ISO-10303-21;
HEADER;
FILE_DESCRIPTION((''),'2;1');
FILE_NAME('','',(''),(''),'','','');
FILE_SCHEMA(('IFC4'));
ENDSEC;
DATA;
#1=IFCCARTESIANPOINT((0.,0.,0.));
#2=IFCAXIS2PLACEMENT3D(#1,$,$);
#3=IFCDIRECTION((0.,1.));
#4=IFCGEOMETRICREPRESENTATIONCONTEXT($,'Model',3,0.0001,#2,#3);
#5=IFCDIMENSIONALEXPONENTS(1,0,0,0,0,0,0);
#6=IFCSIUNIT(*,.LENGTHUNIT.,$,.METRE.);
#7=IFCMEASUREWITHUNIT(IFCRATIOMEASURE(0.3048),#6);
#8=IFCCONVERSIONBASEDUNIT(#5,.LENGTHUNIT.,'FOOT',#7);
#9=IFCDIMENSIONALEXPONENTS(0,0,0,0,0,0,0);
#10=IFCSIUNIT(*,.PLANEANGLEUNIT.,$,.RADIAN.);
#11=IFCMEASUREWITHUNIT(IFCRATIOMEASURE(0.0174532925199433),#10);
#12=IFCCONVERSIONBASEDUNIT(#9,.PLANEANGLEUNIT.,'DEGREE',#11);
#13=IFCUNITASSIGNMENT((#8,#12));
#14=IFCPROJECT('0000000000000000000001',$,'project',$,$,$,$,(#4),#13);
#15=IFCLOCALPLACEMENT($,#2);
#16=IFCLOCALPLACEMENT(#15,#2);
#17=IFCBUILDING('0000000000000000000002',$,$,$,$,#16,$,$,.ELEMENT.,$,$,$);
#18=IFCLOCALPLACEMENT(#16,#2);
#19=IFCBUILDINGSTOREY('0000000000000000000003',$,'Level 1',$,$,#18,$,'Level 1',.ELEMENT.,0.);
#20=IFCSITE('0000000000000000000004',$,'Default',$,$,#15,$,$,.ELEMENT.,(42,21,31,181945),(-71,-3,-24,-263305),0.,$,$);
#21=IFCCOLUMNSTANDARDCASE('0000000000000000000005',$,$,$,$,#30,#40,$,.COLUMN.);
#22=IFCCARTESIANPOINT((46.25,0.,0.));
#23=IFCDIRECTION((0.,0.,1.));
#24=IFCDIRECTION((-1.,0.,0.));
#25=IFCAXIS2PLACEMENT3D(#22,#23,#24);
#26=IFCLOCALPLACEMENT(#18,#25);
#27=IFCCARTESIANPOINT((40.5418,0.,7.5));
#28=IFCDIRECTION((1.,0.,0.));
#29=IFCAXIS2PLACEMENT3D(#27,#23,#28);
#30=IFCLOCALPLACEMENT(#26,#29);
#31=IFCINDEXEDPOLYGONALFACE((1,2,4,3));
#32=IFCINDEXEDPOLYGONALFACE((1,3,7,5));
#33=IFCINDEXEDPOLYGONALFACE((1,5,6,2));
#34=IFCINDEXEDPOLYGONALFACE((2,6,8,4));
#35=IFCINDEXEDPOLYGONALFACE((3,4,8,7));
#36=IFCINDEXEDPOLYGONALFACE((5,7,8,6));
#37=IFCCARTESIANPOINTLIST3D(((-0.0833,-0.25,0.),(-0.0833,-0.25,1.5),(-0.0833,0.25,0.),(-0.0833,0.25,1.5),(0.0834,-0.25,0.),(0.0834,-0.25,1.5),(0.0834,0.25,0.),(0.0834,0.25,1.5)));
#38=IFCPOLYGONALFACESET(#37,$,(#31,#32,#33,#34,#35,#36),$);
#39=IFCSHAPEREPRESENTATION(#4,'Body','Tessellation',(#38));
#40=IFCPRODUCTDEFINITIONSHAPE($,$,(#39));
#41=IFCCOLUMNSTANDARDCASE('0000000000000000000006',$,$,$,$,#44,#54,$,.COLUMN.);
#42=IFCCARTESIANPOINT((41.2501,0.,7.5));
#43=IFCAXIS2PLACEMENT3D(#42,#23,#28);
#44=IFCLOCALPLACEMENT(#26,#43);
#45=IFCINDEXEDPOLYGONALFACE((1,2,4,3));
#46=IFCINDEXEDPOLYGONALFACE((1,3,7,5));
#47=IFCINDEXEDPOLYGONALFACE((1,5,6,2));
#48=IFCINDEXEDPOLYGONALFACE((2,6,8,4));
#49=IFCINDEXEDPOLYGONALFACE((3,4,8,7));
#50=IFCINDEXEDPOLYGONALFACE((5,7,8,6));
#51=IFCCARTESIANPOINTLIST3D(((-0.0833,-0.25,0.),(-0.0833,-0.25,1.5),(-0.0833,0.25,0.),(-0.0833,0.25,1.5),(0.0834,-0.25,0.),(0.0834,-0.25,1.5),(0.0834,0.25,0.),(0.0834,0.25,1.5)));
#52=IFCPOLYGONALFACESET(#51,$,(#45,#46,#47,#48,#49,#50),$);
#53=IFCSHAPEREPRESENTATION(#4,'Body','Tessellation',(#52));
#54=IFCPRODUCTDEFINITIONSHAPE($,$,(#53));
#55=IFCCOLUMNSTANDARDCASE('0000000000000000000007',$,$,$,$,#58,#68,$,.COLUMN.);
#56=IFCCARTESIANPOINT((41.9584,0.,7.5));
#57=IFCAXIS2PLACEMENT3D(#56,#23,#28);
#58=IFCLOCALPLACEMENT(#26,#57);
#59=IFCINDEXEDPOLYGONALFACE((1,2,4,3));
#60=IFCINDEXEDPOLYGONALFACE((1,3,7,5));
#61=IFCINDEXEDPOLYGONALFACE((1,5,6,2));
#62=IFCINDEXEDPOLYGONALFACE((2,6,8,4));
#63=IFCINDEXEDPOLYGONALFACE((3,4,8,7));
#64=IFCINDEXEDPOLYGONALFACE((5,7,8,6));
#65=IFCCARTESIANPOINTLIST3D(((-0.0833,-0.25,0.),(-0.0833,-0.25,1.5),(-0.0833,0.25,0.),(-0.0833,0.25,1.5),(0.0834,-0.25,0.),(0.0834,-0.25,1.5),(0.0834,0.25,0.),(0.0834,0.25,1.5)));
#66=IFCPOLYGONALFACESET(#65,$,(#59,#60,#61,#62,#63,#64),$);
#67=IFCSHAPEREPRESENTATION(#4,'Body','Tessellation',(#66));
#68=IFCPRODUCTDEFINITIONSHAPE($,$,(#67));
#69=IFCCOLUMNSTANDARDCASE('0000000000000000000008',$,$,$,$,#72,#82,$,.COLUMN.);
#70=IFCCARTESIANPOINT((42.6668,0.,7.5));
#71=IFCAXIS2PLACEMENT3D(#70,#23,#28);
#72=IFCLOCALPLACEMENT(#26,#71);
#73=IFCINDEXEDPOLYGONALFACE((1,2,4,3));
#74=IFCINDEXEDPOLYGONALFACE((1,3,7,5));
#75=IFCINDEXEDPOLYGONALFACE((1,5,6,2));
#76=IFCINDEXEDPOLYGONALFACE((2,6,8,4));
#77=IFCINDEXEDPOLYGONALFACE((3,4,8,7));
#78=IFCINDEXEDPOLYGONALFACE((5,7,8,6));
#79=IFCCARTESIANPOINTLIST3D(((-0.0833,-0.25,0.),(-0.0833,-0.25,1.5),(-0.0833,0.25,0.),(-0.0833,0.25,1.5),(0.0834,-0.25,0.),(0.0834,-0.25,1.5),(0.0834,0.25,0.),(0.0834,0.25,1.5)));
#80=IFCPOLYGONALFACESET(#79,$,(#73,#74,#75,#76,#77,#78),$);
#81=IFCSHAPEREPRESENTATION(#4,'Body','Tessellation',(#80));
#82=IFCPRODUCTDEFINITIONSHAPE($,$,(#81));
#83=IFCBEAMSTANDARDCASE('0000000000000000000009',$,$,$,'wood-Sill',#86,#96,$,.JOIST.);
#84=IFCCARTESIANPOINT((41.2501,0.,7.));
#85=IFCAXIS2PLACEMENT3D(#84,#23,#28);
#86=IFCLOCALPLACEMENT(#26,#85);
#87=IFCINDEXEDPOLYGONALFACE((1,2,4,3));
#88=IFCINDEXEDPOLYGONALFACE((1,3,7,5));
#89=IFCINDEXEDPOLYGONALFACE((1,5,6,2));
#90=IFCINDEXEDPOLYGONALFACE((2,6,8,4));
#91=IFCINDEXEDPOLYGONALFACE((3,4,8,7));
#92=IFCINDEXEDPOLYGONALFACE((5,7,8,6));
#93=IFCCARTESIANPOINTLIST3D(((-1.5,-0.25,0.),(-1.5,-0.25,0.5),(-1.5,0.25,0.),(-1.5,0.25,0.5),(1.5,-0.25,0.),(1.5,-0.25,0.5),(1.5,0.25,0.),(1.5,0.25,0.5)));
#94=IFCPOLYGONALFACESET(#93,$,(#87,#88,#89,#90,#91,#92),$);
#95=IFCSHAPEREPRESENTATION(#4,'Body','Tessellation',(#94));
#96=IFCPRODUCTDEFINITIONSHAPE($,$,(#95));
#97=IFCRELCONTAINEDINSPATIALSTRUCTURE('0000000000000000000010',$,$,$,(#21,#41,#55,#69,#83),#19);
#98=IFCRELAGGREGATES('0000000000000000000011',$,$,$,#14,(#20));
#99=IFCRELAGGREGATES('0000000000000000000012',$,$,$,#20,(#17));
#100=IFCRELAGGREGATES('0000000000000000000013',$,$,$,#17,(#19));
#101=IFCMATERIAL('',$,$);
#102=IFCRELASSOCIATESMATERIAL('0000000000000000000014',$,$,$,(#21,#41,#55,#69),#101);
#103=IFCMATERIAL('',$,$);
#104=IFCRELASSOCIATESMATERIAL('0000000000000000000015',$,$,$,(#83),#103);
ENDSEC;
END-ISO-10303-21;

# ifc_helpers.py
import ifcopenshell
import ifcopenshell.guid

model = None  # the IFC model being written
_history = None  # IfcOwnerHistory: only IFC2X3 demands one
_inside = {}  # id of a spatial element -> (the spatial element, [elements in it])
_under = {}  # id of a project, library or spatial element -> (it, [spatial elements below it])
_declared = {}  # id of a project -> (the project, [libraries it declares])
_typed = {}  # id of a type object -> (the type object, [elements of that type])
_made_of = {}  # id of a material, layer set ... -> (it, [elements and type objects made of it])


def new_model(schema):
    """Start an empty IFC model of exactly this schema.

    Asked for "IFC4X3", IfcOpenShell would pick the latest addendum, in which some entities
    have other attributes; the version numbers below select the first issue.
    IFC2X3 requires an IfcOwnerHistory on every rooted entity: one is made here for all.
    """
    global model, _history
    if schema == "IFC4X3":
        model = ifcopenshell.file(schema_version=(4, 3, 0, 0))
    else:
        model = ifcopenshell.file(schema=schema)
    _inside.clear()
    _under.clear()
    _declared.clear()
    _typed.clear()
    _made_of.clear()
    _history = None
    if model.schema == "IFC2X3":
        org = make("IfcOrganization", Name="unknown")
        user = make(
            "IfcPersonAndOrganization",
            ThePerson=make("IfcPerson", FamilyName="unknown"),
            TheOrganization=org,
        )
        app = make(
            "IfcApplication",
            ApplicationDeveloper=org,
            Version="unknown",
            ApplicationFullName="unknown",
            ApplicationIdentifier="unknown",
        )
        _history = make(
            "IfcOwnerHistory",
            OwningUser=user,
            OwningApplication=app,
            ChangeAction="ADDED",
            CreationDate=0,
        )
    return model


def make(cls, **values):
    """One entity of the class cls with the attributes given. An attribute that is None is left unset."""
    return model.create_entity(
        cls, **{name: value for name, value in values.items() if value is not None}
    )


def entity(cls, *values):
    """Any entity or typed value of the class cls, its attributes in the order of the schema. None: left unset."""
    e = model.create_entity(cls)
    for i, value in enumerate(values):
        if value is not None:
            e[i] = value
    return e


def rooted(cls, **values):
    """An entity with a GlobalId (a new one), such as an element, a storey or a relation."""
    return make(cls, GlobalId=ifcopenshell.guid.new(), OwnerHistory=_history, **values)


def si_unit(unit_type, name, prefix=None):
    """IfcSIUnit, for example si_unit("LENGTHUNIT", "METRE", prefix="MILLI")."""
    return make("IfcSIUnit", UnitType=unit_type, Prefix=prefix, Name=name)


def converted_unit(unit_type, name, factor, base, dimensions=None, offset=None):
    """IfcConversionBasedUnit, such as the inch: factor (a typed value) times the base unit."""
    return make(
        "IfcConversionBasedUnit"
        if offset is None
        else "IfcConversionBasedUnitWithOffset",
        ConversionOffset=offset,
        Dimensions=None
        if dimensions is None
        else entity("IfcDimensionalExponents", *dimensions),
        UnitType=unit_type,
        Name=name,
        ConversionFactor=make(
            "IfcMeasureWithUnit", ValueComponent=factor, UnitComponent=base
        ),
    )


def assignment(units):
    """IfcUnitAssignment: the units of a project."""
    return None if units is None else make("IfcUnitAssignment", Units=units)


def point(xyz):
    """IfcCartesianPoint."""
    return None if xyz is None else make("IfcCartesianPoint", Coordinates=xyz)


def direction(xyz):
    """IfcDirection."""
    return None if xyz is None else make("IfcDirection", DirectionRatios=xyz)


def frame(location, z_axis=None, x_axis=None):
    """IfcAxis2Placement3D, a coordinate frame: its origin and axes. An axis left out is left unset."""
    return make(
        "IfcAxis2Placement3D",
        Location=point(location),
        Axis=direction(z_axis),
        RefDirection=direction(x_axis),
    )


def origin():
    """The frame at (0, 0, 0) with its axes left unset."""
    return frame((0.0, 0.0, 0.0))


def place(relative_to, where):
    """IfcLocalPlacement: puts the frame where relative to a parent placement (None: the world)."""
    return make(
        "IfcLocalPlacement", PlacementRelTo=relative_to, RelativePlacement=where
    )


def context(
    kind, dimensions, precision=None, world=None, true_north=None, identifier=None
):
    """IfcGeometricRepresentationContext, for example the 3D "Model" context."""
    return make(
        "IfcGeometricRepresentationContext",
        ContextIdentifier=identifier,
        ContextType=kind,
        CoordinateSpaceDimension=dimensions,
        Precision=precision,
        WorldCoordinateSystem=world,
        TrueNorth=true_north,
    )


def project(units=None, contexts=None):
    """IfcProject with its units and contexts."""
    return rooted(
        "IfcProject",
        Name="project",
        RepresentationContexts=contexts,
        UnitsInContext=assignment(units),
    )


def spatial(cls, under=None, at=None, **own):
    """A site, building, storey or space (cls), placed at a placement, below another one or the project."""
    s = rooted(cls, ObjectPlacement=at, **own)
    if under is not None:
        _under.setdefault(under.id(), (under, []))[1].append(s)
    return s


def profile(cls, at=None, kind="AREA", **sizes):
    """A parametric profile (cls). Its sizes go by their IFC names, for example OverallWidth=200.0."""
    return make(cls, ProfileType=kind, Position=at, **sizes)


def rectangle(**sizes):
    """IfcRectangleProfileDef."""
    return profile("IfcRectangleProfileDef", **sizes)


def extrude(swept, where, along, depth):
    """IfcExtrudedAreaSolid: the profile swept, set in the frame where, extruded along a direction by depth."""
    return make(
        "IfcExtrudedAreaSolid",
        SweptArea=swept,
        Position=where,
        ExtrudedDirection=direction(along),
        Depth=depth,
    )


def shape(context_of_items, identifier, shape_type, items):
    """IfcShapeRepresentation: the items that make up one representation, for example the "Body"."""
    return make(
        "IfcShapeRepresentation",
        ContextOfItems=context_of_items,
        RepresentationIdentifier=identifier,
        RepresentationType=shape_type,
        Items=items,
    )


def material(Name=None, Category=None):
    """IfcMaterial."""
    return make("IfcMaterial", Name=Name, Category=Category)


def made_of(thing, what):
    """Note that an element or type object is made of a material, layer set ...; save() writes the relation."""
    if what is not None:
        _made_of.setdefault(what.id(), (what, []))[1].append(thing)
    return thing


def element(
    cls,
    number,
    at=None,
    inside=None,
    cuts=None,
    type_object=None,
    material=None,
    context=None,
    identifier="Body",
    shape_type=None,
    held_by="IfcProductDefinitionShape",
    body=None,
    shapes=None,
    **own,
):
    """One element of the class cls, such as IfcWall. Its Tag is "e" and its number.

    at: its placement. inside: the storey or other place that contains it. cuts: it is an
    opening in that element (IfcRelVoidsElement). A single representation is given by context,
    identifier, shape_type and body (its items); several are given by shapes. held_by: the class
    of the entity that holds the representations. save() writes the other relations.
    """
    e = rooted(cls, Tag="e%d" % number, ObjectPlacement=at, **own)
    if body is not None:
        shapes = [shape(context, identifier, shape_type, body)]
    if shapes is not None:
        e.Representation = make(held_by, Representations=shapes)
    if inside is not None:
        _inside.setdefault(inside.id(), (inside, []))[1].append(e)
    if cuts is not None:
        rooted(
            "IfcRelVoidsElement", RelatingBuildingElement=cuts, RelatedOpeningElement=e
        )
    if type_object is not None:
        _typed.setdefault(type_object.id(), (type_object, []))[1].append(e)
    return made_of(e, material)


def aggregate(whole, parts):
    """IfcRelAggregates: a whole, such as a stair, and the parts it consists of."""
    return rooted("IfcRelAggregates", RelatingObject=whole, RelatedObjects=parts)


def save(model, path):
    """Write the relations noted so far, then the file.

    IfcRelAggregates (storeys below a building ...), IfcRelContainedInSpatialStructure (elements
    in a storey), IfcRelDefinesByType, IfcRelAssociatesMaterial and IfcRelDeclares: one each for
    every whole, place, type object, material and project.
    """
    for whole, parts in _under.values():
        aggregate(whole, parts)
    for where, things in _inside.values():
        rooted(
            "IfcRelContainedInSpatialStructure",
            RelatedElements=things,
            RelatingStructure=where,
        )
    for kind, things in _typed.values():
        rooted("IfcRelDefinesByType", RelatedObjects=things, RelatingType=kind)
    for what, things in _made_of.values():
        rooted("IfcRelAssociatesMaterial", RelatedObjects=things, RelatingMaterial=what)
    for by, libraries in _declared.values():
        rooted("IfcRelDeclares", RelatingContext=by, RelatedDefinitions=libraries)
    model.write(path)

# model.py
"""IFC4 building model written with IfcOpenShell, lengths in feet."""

from ifc_helpers import new_model, entity, si_unit, converted_unit, direction, frame, origin, place, context, project, spatial, rectangle, extrude, material, element, save


model = new_model("IFC4")

# Units and contexts
model_context = context("Model", 3, precision=0.0001, world=origin(), true_north=direction((0.0, 1.0)))
ifc_project = project(units=[converted_unit("LENGTHUNIT", "FOOT", entity("IfcRatioMeasure", 0.3048), si_unit("LENGTHUNIT", "METRE"), dimensions=[1, 0, 0, 0, 0, 0, 0]), converted_unit("PLANEANGLEUNIT", "DEGREE", entity("IfcRatioMeasure", 0.0174532925199433), si_unit("PLANEANGLEUNIT", "RADIAN"), dimensions=[0, 0, 0, 0, 0, 0, 0])], contexts=[model_context])

# Site, building, storey
site_placement = place(None, origin())
site = spatial("IfcSite", under=ifc_project, at=site_placement, Name="Default", CompositionType="ELEMENT", RefLatitude=(42, 21, 31, 181945), RefLongitude=(-71, -3, -24, -263305), RefElevation=0.0)
building_placement = place(site_placement, origin())
building = spatial("IfcBuilding", under=site, at=building_placement, CompositionType="ELEMENT")
storey_placement = place(building_placement, origin())
storey = spatial("IfcBuildingStorey", under=building, at=storey_placement, Name="Level 1", LongName="Level 1", CompositionType="ELEMENT", Elevation=0.0)

# Columns
ifc_material_1 = material(Name="")
placement_1 = place(storey_placement, frame((46.25, 0.0, 0.0), z_axis=(0.0, 0.0, 1.0), x_axis=(-1.0, 0.0, 0.0)))
for number, where, z_axis, x_axis in (
    (1, (40.5418, 0.0, 7.5), (0.0, 0.0, 1.0), (1.0, 0.0, 0.0)),
    (2, (41.2501, 0.0, 7.5), (0.0, 0.0, 1.0), (1.0, 0.0, 0.0)),
    (3, (41.9584, 0.0, 7.5), (0.0, 0.0, 1.0), (1.0, 0.0, 0.0)),
    (4, (42.6668, 0.0, 7.5), (0.0, 0.0, 1.0), (1.0, 0.0, 0.0)),
):
    element("IfcColumnStandardCase", number, at=place(placement_1, frame(where, z_axis=z_axis, x_axis=x_axis)), inside=storey, material=ifc_material_1, PredefinedType="COLUMN", context=model_context, shape_type="SweptSolid", body=[
        extrude(rectangle(XDim=0.1667, YDim=0.5), origin(), (0.0, 0.0, 1.0), 1.5),
    ])

# Beam
ifc_material_2 = material(Name="")
for number, where, z_axis, x_axis in (
    (5, (41.2501, 0.0, 7.0), (0.0, 0.0, 1.0), (1.0, 0.0, 0.0)),
):
    element("IfcBeamStandardCase", number, at=place(placement_1, frame(where, z_axis=z_axis, x_axis=x_axis)), inside=storey, material=ifc_material_2, ObjectType="wood-Sill", PredefinedType="JOIST", context=model_context, shape_type="SweptSolid", body=[
        extrude(rectangle(XDim=3.0, YDim=0.5), origin(), (0.0, 0.0, 1.0), 0.5),
    ])

save(model, "model.ifc")
